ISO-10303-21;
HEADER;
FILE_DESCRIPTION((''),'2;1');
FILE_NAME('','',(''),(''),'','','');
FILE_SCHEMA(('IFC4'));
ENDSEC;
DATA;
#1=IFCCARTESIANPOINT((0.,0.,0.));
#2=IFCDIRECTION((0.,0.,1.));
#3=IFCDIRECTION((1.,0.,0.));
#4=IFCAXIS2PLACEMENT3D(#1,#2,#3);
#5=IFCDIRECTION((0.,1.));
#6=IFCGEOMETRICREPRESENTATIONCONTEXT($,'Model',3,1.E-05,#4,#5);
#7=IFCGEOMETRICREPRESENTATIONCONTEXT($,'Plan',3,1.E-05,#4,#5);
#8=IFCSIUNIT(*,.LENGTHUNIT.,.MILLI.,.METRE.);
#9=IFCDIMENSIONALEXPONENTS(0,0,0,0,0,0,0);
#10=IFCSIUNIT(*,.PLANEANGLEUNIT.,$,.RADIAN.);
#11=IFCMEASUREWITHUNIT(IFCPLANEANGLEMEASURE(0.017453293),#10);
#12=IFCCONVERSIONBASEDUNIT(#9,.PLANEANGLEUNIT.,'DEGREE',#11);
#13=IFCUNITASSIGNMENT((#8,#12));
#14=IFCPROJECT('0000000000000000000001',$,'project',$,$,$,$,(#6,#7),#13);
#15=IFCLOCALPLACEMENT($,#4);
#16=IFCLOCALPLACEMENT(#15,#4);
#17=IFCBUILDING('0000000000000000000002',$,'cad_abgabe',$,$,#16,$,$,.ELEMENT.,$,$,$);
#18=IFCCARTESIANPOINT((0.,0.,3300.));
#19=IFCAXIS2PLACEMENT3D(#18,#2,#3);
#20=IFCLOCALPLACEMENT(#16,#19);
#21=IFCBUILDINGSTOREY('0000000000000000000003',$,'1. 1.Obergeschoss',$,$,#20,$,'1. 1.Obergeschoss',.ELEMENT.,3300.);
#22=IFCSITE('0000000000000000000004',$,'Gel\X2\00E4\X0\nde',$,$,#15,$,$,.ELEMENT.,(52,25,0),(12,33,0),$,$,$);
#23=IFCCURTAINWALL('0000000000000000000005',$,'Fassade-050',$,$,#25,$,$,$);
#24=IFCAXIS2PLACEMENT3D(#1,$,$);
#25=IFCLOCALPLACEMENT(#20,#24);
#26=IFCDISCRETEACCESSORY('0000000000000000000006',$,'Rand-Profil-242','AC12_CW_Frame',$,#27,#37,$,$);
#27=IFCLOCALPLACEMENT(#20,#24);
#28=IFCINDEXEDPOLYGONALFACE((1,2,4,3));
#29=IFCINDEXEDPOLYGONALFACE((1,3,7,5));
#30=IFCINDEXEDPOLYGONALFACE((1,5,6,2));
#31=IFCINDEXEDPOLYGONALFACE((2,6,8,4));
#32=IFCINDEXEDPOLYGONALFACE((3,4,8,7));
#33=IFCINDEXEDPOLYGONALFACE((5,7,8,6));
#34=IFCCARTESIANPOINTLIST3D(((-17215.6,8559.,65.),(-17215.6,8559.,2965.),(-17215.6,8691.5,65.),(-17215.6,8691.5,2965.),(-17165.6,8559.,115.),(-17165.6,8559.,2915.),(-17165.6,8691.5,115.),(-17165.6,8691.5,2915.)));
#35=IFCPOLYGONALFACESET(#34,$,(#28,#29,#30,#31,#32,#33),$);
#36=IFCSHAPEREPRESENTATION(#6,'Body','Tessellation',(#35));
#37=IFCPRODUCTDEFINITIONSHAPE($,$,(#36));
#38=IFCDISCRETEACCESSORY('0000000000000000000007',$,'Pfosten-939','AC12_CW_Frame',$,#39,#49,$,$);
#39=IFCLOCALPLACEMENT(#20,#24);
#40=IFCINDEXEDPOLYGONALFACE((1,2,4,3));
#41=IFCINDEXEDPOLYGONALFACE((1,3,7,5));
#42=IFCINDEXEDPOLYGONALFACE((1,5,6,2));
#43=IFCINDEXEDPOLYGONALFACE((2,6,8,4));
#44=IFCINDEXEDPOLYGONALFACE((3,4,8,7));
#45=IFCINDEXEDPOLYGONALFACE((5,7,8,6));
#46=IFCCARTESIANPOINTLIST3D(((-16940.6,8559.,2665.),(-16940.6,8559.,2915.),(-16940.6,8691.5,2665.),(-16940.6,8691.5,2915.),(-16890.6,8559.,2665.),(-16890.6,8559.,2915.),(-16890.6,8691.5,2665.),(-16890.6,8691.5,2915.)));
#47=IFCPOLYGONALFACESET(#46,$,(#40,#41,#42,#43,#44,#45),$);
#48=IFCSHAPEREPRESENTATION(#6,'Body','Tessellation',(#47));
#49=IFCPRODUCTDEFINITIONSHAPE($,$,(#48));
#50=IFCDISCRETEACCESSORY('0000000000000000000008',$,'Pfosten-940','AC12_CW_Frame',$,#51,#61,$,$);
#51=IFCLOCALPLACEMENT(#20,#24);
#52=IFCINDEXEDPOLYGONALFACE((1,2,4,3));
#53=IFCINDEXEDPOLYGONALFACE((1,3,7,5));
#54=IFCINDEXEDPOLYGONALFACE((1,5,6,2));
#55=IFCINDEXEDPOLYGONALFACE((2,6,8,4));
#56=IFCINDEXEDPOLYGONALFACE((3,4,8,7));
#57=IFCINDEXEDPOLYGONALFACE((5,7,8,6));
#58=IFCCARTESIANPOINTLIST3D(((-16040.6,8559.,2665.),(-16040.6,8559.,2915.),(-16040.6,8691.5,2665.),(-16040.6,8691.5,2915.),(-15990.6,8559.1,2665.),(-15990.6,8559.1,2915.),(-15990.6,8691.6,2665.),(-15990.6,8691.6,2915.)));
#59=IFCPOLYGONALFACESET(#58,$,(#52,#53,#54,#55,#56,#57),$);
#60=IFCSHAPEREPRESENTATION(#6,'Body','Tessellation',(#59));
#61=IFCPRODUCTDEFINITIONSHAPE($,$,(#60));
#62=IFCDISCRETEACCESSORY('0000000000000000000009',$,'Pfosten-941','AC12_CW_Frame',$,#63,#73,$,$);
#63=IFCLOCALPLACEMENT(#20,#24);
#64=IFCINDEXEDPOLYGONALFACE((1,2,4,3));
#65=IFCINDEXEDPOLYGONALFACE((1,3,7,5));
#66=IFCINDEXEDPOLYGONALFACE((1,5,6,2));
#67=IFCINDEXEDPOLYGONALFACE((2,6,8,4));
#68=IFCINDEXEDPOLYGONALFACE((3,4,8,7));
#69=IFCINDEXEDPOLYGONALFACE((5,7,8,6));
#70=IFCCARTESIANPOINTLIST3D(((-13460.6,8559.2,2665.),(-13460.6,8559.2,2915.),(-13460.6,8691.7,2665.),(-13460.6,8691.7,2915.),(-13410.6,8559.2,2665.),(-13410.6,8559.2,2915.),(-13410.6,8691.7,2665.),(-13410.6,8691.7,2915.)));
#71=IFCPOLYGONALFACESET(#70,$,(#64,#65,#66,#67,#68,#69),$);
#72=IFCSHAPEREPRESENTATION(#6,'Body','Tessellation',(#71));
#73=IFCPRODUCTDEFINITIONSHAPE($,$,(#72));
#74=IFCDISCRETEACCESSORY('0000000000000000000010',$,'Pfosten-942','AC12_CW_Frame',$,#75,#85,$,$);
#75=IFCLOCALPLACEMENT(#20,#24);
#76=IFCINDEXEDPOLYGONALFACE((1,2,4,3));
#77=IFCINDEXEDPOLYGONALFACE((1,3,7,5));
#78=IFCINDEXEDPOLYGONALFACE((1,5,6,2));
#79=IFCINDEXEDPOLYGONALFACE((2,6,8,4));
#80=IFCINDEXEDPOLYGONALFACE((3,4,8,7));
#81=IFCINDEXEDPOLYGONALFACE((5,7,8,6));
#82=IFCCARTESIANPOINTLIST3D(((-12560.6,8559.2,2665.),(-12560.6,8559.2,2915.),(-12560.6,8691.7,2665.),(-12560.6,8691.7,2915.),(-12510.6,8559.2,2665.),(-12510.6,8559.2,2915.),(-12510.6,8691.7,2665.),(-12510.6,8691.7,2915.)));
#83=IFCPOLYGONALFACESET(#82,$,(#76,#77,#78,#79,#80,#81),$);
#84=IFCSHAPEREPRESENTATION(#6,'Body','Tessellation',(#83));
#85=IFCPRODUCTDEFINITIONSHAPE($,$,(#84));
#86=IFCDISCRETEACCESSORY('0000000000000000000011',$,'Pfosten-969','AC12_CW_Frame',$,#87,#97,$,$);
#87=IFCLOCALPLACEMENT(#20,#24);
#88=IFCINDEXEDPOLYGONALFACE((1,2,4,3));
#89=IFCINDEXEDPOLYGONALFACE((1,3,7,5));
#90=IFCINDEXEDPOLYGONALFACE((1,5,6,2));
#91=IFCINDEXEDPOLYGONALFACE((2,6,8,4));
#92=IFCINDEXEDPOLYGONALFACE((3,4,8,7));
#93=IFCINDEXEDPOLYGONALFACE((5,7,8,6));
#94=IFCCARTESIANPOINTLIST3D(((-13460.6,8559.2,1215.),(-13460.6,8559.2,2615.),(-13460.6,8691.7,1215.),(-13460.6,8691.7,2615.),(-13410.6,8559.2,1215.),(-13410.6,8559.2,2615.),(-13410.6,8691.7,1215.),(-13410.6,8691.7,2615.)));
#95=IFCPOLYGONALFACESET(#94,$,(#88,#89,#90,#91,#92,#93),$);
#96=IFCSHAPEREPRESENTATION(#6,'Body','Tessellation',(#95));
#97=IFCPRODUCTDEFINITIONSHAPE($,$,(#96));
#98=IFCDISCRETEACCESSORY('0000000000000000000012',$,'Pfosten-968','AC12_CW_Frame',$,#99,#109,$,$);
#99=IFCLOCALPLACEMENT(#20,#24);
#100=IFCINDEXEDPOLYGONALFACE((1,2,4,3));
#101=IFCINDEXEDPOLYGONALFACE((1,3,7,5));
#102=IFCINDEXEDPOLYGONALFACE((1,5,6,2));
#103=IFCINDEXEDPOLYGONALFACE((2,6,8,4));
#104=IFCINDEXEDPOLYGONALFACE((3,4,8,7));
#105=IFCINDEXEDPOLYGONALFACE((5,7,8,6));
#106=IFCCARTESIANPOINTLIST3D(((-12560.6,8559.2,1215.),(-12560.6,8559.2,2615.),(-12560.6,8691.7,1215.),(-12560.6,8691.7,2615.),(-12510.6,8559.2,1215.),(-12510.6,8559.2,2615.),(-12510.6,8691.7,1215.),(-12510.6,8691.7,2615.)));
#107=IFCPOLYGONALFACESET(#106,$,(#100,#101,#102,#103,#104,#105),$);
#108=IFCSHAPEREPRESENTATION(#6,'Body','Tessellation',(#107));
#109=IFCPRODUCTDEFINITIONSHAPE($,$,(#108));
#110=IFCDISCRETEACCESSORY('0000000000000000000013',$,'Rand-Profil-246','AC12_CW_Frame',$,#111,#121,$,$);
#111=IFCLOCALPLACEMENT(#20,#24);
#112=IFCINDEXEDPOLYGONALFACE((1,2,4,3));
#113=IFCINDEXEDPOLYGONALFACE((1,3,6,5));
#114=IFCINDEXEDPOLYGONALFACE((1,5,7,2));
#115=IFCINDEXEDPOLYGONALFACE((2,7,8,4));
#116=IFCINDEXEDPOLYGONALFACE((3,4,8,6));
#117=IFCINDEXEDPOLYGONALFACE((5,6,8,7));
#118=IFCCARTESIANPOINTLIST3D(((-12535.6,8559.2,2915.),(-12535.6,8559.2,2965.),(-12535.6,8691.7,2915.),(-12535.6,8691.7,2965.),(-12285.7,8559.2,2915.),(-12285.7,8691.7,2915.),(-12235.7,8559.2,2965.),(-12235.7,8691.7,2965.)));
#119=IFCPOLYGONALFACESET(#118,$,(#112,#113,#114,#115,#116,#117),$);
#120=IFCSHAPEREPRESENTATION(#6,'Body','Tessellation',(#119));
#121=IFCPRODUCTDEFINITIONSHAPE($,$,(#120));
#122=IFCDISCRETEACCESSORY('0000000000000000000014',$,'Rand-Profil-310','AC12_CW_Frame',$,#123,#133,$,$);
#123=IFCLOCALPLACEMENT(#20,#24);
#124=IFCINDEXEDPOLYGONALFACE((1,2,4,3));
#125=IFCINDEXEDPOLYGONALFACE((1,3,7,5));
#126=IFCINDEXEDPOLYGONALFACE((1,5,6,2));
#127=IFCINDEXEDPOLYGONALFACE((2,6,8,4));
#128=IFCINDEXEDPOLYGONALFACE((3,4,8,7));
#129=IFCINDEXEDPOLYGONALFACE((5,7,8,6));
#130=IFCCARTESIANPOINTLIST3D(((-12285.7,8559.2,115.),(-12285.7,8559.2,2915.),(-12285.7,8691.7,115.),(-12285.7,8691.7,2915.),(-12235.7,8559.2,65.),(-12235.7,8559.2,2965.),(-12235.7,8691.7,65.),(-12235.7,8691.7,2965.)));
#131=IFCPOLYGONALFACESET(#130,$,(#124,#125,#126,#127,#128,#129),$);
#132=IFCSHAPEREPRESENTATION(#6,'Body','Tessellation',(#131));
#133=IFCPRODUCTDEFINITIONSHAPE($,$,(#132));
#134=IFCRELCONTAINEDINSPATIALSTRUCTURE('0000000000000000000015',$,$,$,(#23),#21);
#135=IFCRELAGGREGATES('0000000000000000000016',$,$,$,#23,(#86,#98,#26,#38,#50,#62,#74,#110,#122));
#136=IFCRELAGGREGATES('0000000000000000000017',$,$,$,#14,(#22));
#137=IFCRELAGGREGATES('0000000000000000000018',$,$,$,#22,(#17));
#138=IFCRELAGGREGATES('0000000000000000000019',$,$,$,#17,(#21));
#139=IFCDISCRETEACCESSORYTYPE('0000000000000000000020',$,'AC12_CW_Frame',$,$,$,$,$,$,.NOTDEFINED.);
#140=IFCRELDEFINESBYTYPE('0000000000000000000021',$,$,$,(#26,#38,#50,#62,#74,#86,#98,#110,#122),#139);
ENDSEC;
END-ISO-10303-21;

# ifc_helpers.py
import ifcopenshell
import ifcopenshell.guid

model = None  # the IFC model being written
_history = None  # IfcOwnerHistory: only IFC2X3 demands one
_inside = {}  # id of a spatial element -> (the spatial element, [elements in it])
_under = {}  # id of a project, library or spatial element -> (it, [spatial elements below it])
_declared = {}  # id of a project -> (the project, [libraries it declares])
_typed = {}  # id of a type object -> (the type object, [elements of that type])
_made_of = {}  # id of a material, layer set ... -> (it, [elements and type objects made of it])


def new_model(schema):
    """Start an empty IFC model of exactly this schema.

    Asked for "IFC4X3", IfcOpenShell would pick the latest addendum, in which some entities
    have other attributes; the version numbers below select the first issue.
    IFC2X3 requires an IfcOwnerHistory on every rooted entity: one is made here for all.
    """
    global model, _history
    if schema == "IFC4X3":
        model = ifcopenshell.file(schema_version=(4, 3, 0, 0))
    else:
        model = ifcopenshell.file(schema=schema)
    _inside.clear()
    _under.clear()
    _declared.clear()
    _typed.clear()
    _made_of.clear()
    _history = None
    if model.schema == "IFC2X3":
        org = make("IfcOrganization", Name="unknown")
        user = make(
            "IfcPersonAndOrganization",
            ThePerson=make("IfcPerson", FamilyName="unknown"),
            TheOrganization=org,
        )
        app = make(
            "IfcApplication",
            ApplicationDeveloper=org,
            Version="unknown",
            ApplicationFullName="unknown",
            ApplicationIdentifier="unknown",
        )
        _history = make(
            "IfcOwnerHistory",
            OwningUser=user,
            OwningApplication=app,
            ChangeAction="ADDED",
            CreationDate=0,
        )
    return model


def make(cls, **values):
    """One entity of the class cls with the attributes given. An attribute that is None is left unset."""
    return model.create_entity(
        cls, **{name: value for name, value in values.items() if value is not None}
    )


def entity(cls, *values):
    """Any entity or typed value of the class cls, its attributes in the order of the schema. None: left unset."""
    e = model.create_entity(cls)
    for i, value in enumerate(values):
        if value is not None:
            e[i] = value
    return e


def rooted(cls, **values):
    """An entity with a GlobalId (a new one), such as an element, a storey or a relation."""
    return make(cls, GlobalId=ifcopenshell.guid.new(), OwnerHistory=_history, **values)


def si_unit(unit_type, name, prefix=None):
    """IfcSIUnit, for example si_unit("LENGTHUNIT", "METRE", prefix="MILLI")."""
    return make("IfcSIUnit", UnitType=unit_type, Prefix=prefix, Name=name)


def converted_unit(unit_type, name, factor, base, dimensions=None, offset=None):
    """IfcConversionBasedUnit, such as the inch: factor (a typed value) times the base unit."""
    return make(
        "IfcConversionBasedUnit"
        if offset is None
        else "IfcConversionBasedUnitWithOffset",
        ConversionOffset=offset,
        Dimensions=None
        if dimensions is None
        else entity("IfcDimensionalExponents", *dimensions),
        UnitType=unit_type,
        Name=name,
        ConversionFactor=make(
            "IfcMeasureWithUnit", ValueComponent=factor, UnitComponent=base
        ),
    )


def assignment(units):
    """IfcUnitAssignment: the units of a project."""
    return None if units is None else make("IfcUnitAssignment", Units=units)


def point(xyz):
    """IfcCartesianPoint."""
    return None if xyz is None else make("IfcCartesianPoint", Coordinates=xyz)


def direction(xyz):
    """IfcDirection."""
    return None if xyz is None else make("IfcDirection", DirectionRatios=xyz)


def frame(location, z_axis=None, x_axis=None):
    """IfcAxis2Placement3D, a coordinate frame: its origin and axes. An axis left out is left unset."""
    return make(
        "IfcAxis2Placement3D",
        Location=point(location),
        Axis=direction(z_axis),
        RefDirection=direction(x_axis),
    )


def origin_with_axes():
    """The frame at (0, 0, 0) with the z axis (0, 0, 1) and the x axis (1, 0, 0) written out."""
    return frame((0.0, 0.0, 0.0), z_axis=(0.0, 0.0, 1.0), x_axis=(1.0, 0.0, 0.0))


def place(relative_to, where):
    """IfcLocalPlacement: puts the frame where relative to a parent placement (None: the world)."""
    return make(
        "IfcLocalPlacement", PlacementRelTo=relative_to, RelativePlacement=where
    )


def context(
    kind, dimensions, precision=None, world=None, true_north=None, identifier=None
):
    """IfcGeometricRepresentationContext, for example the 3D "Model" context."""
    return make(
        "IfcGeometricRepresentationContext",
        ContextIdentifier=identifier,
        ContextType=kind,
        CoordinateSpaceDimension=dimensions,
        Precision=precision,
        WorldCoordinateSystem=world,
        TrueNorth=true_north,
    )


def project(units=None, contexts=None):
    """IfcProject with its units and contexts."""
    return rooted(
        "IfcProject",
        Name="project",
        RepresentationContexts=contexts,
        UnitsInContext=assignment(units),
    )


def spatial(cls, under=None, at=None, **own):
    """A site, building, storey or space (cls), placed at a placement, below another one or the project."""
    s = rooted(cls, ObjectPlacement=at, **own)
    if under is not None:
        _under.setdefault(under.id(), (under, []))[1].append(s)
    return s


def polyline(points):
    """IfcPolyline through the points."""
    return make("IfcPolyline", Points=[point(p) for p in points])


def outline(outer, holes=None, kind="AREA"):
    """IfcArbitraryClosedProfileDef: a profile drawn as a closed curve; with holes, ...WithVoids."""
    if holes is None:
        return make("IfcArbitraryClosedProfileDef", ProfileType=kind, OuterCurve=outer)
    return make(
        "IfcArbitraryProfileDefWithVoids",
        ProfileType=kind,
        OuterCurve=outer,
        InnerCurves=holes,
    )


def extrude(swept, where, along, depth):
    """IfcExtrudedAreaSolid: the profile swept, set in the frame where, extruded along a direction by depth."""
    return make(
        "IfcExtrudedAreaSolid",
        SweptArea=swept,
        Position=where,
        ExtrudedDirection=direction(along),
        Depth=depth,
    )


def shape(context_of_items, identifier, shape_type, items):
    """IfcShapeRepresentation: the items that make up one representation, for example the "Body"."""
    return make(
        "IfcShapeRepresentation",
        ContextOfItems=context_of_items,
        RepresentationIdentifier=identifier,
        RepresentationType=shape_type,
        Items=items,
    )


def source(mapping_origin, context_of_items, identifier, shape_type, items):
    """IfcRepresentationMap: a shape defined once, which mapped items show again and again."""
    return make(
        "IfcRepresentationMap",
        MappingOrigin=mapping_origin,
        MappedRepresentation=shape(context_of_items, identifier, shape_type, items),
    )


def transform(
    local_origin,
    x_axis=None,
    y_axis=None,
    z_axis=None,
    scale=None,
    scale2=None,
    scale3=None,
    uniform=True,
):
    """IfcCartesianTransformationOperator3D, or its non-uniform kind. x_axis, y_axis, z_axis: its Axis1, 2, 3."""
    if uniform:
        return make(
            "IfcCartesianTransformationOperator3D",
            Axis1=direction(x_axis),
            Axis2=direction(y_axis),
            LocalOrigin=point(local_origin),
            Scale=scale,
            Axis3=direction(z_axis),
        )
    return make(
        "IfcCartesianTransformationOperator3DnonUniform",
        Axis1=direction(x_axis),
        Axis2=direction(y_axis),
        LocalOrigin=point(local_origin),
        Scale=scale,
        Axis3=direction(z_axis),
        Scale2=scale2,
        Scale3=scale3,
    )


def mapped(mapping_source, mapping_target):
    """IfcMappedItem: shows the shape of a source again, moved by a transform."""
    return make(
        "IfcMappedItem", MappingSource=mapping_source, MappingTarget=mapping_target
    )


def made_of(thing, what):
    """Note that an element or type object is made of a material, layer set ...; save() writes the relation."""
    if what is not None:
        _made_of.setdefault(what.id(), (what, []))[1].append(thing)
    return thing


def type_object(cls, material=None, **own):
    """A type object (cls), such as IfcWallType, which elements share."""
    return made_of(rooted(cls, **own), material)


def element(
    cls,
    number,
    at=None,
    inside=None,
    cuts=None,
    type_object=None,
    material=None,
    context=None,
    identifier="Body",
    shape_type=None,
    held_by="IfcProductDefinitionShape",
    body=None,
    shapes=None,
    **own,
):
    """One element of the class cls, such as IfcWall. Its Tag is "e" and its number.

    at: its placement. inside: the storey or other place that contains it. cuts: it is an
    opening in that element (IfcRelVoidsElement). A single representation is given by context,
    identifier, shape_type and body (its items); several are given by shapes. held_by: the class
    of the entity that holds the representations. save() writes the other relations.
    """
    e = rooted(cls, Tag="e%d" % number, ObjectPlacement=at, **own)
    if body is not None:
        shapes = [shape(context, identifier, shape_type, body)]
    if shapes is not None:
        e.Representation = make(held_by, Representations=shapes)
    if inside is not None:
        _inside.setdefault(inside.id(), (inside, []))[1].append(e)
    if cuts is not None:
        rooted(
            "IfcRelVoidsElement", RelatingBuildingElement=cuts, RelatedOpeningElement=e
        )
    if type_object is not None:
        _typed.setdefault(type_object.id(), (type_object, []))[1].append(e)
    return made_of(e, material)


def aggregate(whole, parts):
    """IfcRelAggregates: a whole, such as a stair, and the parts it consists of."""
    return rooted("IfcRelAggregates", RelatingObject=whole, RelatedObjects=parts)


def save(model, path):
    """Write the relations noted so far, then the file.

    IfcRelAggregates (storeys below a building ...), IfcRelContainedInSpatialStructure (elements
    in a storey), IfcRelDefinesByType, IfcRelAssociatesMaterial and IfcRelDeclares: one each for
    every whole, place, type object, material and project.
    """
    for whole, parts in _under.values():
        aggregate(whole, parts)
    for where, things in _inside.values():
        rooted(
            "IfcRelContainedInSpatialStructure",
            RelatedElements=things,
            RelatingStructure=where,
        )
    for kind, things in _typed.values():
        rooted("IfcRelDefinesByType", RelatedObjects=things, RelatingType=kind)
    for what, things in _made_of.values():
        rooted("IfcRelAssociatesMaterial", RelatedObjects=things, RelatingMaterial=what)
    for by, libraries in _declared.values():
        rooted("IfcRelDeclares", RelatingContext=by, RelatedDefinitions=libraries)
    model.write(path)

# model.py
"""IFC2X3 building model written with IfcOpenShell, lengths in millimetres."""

from ifc_helpers import new_model, entity, si_unit, converted_unit, direction, frame, origin_with_axes, place, context, project, spatial, polyline, outline, extrude, source, transform, mapped, type_object, element, aggregate, save


model = new_model("IFC2X3")

# Units and contexts
model_context = context("Model", 3, precision=1e-05, world=origin_with_axes(), true_north=direction((0.0, 1.0)))
plan_context = context("Plan", 3, precision=1e-05, world=origin_with_axes(), true_north=direction((0.0, 1.0)))
ifc_project = project(units=[si_unit("LENGTHUNIT", "METRE", prefix="MILLI"), converted_unit("PLANEANGLEUNIT", "DEGREE", entity("IfcPlaneAngleMeasure", 0.017453293), si_unit("PLANEANGLEUNIT", "RADIAN"), dimensions=[0, 0, 0, 0, 0, 0, 0])], contexts=[model_context, plan_context])

# Site, building, storey
site_placement = place(None, origin_with_axes())
site = spatial("IfcSite", under=ifc_project, at=site_placement, Name="Gelände", CompositionType="ELEMENT", RefLatitude=(52, 25, 0), RefLongitude=(12, 33, 0))
building_placement = place(site_placement, origin_with_axes())
building = spatial("IfcBuilding", under=site, at=building_placement, Name="cad_abgabe", CompositionType="ELEMENT")
storey_placement = place(building_placement, frame((0.0, 0.0, 3300.0), z_axis=(0.0, 0.0, 1.0), x_axis=(1.0, 0.0, 0.0)))
storey = spatial("IfcBuildingStorey", under=building, at=storey_placement, Name="1. 1.Obergeschoss", LongName="1. 1.Obergeschoss", CompositionType="ELEMENT", Elevation=3300.0)

# Curtain wall
curtain_wall_placement = place(storey_placement, frame((-17190.6, 8614.0, 90.0), z_axis=(0.0, 0.0, 1.0), x_axis=(1.0, 0.000045, 0.0)))
curtain_wall = element("IfcCurtainWall", 1, at=curtain_wall_placement, inside=storey, Name="Fassade-050")

# Discrete accessories
discrete_accessory_type = type_object("IfcDiscreteAccessoryType", Name="AC12_CW_Frame")
shared_shape_1 = source(origin_with_axes(), model_context, "Body", "SweptSolid", [
    extrude(outline(polyline([(0.0, 0.0), (70.7, 0.0), (2050.6, -1979.9), (2050.6, -2050.6), (0.0, 0.0)])), origin_with_axes(), (0.0, 0.0, 1.0), 132.5),
])
discrete_accessory_1_placement = place(storey_placement, frame((-17215.6, 8559.0, 65.0), z_axis=(-0.000045, 1.0, 0.0), x_axis=(0.707107, 0.000032, 0.707107)))
discrete_accessory_1 = element("IfcDiscreteAccessory", 2, at=discrete_accessory_1_placement, type_object=discrete_accessory_type, Name="Rand-Profil-242", Description="AC12_CW_Frame", context=model_context, shape_type="MappedRepresentation", body=[
    mapped(shared_shape_1, transform((0.0, 0.0, 0.0), scale=1.0)),
])
shared_shape_2 = source(origin_with_axes(), model_context, "Body", "SweptSolid", [
    extrude(outline(polyline([(0.0, 0.0), (132.5, 0.0), (132.5, -250.0), (0.0, -250.0), (0.0, 0.0)])), origin_with_axes(), (0.0, 0.0, 1.0), 50.0),
])
discrete_accessory_2_placement = place(storey_placement, frame((-16940.6, 8691.5, 2665.0), z_axis=(1.0, 0.000045, 0.0), x_axis=(0.000045, -1.0, 0.0)))
discrete_accessory_2 = element("IfcDiscreteAccessory", 3, at=discrete_accessory_2_placement, type_object=discrete_accessory_type, Name="Pfosten-939", Description="AC12_CW_Frame", context=model_context, shape_type="MappedRepresentation", body=[
    mapped(shared_shape_2, transform((0.0, 0.0, 0.0), scale=1.0)),
])
discrete_accessory_3_placement = place(storey_placement, frame((-16040.6, 8691.5, 2665.0), z_axis=(1.0, 0.000045, 0.0), x_axis=(0.000045, -1.0, 0.0)))
discrete_accessory_3 = element("IfcDiscreteAccessory", 4, at=discrete_accessory_3_placement, type_object=discrete_accessory_type, Name="Pfosten-940", Description="AC12_CW_Frame", context=model_context, shape_type="MappedRepresentation", body=[
    mapped(shared_shape_2, transform((0.0, 0.0, 0.0), scale=1.0)),
])
discrete_accessory_4_placement = place(storey_placement, frame((-13460.6, 8691.7, 2665.0), z_axis=(1.0, 0.000045, 0.0), x_axis=(0.000045, -1.0, 0.0)))
discrete_accessory_4 = element("IfcDiscreteAccessory", 5, at=discrete_accessory_4_placement, type_object=discrete_accessory_type, Name="Pfosten-941", Description="AC12_CW_Frame", context=model_context, shape_type="MappedRepresentation", body=[
    mapped(shared_shape_2, transform((0.0, 0.0, 0.0), scale=1.0)),
])
discrete_accessory_5_placement = place(storey_placement, frame((-12560.6, 8691.7, 2665.0), z_axis=(1.0, 0.000045, 0.0), x_axis=(0.000045, -1.0, 0.0)))
discrete_accessory_5 = element("IfcDiscreteAccessory", 6, at=discrete_accessory_5_placement, type_object=discrete_accessory_type, Name="Pfosten-942", Description="AC12_CW_Frame", context=model_context, shape_type="MappedRepresentation", body=[
    mapped(shared_shape_2, transform((0.0, 0.0, 0.0), scale=1.0)),
])
shared_shape_3 = source(origin_with_axes(), model_context, "Body", "SweptSolid", [
    extrude(outline(polyline([(0.0, 0.0), (132.5, 0.0), (132.5, -1400.0), (0.0, -1400.0), (0.0, 0.0)])), origin_with_axes(), (0.0, 0.0, 1.0), 50.0),
])
discrete_accessory_6_placement = place(storey_placement, frame((-13460.6, 8691.7, 1215.0), z_axis=(1.0, 0.000045, 0.0), x_axis=(0.000045, -1.0, 0.0)))
discrete_accessory_6 = element("IfcDiscreteAccessory", 7, at=discrete_accessory_6_placement, type_object=discrete_accessory_type, Name="Pfosten-969", Description="AC12_CW_Frame", context=model_context, shape_type="MappedRepresentation", body=[
    mapped(shared_shape_3, transform((0.0, 0.0, 0.0), scale=1.0)),
])
discrete_accessory_7_placement = place(storey_placement, frame((-12560.6, 8691.7, 1215.0), z_axis=(1.0, 0.000045, 0.0), x_axis=(0.000045, -1.0, 0.0)))
discrete_accessory_7 = element("IfcDiscreteAccessory", 8, at=discrete_accessory_7_placement, type_object=discrete_accessory_type, Name="Pfosten-968", Description="AC12_CW_Frame", context=model_context, shape_type="MappedRepresentation", body=[
    mapped(shared_shape_3, transform((0.0, 0.0, 0.0), scale=1.0)),
])
shared_shape_4 = source(origin_with_axes(), model_context, "Body", "SweptSolid", [
    extrude(outline(polyline([(0.0, 0.0), (70.7, 0.0), (-141.3, -212.0), (-176.6, -176.6), (0.0, 0.0)])), origin_with_axes(), (0.0, 0.0, 1.0), 132.5),
])
discrete_accessory_8_placement = place(storey_placement, frame((-12285.7, 8559.2, 2915.0), z_axis=(-0.000045, 1.0, 0.0), x_axis=(0.707107, 0.000032, 0.707107)))
discrete_accessory_8 = element("IfcDiscreteAccessory", 9, at=discrete_accessory_8_placement, type_object=discrete_accessory_type, Name="Rand-Profil-246", Description="AC12_CW_Frame", context=model_context, shape_type="MappedRepresentation", body=[
    mapped(shared_shape_4, transform((0.0, 0.0, 0.0), scale=1.0)),
])
shared_shape_5 = source(origin_with_axes(), model_context, "Body", "SweptSolid", [
    extrude(outline(polyline([(0.0, 0.0), (70.7, 0.0), (-1979.9, -2050.6), (-1979.9, -1979.9), (0.0, 0.0)])), origin_with_axes(), (0.0, 0.0, 1.0), 132.5),
])
discrete_accessory_9_placement = place(storey_placement, frame((-12285.7, 8559.2, 115.0), z_axis=(-0.000045, 1.0, 0.0), x_axis=(0.707107, 0.000032, -0.707107)))
discrete_accessory_9 = element("IfcDiscreteAccessory", 10, at=discrete_accessory_9_placement, type_object=discrete_accessory_type, Name="Rand-Profil-310", Description="AC12_CW_Frame", context=model_context, shape_type="MappedRepresentation", body=[
    mapped(shared_shape_5, transform((0.0, 0.0, 0.0), scale=1.0)),
])
aggregate(curtain_wall, [discrete_accessory_6, discrete_accessory_7, discrete_accessory_1, discrete_accessory_2, discrete_accessory_3, discrete_accessory_4, discrete_accessory_5, discrete_accessory_8, discrete_accessory_9])

save(model, "model.ifc")
